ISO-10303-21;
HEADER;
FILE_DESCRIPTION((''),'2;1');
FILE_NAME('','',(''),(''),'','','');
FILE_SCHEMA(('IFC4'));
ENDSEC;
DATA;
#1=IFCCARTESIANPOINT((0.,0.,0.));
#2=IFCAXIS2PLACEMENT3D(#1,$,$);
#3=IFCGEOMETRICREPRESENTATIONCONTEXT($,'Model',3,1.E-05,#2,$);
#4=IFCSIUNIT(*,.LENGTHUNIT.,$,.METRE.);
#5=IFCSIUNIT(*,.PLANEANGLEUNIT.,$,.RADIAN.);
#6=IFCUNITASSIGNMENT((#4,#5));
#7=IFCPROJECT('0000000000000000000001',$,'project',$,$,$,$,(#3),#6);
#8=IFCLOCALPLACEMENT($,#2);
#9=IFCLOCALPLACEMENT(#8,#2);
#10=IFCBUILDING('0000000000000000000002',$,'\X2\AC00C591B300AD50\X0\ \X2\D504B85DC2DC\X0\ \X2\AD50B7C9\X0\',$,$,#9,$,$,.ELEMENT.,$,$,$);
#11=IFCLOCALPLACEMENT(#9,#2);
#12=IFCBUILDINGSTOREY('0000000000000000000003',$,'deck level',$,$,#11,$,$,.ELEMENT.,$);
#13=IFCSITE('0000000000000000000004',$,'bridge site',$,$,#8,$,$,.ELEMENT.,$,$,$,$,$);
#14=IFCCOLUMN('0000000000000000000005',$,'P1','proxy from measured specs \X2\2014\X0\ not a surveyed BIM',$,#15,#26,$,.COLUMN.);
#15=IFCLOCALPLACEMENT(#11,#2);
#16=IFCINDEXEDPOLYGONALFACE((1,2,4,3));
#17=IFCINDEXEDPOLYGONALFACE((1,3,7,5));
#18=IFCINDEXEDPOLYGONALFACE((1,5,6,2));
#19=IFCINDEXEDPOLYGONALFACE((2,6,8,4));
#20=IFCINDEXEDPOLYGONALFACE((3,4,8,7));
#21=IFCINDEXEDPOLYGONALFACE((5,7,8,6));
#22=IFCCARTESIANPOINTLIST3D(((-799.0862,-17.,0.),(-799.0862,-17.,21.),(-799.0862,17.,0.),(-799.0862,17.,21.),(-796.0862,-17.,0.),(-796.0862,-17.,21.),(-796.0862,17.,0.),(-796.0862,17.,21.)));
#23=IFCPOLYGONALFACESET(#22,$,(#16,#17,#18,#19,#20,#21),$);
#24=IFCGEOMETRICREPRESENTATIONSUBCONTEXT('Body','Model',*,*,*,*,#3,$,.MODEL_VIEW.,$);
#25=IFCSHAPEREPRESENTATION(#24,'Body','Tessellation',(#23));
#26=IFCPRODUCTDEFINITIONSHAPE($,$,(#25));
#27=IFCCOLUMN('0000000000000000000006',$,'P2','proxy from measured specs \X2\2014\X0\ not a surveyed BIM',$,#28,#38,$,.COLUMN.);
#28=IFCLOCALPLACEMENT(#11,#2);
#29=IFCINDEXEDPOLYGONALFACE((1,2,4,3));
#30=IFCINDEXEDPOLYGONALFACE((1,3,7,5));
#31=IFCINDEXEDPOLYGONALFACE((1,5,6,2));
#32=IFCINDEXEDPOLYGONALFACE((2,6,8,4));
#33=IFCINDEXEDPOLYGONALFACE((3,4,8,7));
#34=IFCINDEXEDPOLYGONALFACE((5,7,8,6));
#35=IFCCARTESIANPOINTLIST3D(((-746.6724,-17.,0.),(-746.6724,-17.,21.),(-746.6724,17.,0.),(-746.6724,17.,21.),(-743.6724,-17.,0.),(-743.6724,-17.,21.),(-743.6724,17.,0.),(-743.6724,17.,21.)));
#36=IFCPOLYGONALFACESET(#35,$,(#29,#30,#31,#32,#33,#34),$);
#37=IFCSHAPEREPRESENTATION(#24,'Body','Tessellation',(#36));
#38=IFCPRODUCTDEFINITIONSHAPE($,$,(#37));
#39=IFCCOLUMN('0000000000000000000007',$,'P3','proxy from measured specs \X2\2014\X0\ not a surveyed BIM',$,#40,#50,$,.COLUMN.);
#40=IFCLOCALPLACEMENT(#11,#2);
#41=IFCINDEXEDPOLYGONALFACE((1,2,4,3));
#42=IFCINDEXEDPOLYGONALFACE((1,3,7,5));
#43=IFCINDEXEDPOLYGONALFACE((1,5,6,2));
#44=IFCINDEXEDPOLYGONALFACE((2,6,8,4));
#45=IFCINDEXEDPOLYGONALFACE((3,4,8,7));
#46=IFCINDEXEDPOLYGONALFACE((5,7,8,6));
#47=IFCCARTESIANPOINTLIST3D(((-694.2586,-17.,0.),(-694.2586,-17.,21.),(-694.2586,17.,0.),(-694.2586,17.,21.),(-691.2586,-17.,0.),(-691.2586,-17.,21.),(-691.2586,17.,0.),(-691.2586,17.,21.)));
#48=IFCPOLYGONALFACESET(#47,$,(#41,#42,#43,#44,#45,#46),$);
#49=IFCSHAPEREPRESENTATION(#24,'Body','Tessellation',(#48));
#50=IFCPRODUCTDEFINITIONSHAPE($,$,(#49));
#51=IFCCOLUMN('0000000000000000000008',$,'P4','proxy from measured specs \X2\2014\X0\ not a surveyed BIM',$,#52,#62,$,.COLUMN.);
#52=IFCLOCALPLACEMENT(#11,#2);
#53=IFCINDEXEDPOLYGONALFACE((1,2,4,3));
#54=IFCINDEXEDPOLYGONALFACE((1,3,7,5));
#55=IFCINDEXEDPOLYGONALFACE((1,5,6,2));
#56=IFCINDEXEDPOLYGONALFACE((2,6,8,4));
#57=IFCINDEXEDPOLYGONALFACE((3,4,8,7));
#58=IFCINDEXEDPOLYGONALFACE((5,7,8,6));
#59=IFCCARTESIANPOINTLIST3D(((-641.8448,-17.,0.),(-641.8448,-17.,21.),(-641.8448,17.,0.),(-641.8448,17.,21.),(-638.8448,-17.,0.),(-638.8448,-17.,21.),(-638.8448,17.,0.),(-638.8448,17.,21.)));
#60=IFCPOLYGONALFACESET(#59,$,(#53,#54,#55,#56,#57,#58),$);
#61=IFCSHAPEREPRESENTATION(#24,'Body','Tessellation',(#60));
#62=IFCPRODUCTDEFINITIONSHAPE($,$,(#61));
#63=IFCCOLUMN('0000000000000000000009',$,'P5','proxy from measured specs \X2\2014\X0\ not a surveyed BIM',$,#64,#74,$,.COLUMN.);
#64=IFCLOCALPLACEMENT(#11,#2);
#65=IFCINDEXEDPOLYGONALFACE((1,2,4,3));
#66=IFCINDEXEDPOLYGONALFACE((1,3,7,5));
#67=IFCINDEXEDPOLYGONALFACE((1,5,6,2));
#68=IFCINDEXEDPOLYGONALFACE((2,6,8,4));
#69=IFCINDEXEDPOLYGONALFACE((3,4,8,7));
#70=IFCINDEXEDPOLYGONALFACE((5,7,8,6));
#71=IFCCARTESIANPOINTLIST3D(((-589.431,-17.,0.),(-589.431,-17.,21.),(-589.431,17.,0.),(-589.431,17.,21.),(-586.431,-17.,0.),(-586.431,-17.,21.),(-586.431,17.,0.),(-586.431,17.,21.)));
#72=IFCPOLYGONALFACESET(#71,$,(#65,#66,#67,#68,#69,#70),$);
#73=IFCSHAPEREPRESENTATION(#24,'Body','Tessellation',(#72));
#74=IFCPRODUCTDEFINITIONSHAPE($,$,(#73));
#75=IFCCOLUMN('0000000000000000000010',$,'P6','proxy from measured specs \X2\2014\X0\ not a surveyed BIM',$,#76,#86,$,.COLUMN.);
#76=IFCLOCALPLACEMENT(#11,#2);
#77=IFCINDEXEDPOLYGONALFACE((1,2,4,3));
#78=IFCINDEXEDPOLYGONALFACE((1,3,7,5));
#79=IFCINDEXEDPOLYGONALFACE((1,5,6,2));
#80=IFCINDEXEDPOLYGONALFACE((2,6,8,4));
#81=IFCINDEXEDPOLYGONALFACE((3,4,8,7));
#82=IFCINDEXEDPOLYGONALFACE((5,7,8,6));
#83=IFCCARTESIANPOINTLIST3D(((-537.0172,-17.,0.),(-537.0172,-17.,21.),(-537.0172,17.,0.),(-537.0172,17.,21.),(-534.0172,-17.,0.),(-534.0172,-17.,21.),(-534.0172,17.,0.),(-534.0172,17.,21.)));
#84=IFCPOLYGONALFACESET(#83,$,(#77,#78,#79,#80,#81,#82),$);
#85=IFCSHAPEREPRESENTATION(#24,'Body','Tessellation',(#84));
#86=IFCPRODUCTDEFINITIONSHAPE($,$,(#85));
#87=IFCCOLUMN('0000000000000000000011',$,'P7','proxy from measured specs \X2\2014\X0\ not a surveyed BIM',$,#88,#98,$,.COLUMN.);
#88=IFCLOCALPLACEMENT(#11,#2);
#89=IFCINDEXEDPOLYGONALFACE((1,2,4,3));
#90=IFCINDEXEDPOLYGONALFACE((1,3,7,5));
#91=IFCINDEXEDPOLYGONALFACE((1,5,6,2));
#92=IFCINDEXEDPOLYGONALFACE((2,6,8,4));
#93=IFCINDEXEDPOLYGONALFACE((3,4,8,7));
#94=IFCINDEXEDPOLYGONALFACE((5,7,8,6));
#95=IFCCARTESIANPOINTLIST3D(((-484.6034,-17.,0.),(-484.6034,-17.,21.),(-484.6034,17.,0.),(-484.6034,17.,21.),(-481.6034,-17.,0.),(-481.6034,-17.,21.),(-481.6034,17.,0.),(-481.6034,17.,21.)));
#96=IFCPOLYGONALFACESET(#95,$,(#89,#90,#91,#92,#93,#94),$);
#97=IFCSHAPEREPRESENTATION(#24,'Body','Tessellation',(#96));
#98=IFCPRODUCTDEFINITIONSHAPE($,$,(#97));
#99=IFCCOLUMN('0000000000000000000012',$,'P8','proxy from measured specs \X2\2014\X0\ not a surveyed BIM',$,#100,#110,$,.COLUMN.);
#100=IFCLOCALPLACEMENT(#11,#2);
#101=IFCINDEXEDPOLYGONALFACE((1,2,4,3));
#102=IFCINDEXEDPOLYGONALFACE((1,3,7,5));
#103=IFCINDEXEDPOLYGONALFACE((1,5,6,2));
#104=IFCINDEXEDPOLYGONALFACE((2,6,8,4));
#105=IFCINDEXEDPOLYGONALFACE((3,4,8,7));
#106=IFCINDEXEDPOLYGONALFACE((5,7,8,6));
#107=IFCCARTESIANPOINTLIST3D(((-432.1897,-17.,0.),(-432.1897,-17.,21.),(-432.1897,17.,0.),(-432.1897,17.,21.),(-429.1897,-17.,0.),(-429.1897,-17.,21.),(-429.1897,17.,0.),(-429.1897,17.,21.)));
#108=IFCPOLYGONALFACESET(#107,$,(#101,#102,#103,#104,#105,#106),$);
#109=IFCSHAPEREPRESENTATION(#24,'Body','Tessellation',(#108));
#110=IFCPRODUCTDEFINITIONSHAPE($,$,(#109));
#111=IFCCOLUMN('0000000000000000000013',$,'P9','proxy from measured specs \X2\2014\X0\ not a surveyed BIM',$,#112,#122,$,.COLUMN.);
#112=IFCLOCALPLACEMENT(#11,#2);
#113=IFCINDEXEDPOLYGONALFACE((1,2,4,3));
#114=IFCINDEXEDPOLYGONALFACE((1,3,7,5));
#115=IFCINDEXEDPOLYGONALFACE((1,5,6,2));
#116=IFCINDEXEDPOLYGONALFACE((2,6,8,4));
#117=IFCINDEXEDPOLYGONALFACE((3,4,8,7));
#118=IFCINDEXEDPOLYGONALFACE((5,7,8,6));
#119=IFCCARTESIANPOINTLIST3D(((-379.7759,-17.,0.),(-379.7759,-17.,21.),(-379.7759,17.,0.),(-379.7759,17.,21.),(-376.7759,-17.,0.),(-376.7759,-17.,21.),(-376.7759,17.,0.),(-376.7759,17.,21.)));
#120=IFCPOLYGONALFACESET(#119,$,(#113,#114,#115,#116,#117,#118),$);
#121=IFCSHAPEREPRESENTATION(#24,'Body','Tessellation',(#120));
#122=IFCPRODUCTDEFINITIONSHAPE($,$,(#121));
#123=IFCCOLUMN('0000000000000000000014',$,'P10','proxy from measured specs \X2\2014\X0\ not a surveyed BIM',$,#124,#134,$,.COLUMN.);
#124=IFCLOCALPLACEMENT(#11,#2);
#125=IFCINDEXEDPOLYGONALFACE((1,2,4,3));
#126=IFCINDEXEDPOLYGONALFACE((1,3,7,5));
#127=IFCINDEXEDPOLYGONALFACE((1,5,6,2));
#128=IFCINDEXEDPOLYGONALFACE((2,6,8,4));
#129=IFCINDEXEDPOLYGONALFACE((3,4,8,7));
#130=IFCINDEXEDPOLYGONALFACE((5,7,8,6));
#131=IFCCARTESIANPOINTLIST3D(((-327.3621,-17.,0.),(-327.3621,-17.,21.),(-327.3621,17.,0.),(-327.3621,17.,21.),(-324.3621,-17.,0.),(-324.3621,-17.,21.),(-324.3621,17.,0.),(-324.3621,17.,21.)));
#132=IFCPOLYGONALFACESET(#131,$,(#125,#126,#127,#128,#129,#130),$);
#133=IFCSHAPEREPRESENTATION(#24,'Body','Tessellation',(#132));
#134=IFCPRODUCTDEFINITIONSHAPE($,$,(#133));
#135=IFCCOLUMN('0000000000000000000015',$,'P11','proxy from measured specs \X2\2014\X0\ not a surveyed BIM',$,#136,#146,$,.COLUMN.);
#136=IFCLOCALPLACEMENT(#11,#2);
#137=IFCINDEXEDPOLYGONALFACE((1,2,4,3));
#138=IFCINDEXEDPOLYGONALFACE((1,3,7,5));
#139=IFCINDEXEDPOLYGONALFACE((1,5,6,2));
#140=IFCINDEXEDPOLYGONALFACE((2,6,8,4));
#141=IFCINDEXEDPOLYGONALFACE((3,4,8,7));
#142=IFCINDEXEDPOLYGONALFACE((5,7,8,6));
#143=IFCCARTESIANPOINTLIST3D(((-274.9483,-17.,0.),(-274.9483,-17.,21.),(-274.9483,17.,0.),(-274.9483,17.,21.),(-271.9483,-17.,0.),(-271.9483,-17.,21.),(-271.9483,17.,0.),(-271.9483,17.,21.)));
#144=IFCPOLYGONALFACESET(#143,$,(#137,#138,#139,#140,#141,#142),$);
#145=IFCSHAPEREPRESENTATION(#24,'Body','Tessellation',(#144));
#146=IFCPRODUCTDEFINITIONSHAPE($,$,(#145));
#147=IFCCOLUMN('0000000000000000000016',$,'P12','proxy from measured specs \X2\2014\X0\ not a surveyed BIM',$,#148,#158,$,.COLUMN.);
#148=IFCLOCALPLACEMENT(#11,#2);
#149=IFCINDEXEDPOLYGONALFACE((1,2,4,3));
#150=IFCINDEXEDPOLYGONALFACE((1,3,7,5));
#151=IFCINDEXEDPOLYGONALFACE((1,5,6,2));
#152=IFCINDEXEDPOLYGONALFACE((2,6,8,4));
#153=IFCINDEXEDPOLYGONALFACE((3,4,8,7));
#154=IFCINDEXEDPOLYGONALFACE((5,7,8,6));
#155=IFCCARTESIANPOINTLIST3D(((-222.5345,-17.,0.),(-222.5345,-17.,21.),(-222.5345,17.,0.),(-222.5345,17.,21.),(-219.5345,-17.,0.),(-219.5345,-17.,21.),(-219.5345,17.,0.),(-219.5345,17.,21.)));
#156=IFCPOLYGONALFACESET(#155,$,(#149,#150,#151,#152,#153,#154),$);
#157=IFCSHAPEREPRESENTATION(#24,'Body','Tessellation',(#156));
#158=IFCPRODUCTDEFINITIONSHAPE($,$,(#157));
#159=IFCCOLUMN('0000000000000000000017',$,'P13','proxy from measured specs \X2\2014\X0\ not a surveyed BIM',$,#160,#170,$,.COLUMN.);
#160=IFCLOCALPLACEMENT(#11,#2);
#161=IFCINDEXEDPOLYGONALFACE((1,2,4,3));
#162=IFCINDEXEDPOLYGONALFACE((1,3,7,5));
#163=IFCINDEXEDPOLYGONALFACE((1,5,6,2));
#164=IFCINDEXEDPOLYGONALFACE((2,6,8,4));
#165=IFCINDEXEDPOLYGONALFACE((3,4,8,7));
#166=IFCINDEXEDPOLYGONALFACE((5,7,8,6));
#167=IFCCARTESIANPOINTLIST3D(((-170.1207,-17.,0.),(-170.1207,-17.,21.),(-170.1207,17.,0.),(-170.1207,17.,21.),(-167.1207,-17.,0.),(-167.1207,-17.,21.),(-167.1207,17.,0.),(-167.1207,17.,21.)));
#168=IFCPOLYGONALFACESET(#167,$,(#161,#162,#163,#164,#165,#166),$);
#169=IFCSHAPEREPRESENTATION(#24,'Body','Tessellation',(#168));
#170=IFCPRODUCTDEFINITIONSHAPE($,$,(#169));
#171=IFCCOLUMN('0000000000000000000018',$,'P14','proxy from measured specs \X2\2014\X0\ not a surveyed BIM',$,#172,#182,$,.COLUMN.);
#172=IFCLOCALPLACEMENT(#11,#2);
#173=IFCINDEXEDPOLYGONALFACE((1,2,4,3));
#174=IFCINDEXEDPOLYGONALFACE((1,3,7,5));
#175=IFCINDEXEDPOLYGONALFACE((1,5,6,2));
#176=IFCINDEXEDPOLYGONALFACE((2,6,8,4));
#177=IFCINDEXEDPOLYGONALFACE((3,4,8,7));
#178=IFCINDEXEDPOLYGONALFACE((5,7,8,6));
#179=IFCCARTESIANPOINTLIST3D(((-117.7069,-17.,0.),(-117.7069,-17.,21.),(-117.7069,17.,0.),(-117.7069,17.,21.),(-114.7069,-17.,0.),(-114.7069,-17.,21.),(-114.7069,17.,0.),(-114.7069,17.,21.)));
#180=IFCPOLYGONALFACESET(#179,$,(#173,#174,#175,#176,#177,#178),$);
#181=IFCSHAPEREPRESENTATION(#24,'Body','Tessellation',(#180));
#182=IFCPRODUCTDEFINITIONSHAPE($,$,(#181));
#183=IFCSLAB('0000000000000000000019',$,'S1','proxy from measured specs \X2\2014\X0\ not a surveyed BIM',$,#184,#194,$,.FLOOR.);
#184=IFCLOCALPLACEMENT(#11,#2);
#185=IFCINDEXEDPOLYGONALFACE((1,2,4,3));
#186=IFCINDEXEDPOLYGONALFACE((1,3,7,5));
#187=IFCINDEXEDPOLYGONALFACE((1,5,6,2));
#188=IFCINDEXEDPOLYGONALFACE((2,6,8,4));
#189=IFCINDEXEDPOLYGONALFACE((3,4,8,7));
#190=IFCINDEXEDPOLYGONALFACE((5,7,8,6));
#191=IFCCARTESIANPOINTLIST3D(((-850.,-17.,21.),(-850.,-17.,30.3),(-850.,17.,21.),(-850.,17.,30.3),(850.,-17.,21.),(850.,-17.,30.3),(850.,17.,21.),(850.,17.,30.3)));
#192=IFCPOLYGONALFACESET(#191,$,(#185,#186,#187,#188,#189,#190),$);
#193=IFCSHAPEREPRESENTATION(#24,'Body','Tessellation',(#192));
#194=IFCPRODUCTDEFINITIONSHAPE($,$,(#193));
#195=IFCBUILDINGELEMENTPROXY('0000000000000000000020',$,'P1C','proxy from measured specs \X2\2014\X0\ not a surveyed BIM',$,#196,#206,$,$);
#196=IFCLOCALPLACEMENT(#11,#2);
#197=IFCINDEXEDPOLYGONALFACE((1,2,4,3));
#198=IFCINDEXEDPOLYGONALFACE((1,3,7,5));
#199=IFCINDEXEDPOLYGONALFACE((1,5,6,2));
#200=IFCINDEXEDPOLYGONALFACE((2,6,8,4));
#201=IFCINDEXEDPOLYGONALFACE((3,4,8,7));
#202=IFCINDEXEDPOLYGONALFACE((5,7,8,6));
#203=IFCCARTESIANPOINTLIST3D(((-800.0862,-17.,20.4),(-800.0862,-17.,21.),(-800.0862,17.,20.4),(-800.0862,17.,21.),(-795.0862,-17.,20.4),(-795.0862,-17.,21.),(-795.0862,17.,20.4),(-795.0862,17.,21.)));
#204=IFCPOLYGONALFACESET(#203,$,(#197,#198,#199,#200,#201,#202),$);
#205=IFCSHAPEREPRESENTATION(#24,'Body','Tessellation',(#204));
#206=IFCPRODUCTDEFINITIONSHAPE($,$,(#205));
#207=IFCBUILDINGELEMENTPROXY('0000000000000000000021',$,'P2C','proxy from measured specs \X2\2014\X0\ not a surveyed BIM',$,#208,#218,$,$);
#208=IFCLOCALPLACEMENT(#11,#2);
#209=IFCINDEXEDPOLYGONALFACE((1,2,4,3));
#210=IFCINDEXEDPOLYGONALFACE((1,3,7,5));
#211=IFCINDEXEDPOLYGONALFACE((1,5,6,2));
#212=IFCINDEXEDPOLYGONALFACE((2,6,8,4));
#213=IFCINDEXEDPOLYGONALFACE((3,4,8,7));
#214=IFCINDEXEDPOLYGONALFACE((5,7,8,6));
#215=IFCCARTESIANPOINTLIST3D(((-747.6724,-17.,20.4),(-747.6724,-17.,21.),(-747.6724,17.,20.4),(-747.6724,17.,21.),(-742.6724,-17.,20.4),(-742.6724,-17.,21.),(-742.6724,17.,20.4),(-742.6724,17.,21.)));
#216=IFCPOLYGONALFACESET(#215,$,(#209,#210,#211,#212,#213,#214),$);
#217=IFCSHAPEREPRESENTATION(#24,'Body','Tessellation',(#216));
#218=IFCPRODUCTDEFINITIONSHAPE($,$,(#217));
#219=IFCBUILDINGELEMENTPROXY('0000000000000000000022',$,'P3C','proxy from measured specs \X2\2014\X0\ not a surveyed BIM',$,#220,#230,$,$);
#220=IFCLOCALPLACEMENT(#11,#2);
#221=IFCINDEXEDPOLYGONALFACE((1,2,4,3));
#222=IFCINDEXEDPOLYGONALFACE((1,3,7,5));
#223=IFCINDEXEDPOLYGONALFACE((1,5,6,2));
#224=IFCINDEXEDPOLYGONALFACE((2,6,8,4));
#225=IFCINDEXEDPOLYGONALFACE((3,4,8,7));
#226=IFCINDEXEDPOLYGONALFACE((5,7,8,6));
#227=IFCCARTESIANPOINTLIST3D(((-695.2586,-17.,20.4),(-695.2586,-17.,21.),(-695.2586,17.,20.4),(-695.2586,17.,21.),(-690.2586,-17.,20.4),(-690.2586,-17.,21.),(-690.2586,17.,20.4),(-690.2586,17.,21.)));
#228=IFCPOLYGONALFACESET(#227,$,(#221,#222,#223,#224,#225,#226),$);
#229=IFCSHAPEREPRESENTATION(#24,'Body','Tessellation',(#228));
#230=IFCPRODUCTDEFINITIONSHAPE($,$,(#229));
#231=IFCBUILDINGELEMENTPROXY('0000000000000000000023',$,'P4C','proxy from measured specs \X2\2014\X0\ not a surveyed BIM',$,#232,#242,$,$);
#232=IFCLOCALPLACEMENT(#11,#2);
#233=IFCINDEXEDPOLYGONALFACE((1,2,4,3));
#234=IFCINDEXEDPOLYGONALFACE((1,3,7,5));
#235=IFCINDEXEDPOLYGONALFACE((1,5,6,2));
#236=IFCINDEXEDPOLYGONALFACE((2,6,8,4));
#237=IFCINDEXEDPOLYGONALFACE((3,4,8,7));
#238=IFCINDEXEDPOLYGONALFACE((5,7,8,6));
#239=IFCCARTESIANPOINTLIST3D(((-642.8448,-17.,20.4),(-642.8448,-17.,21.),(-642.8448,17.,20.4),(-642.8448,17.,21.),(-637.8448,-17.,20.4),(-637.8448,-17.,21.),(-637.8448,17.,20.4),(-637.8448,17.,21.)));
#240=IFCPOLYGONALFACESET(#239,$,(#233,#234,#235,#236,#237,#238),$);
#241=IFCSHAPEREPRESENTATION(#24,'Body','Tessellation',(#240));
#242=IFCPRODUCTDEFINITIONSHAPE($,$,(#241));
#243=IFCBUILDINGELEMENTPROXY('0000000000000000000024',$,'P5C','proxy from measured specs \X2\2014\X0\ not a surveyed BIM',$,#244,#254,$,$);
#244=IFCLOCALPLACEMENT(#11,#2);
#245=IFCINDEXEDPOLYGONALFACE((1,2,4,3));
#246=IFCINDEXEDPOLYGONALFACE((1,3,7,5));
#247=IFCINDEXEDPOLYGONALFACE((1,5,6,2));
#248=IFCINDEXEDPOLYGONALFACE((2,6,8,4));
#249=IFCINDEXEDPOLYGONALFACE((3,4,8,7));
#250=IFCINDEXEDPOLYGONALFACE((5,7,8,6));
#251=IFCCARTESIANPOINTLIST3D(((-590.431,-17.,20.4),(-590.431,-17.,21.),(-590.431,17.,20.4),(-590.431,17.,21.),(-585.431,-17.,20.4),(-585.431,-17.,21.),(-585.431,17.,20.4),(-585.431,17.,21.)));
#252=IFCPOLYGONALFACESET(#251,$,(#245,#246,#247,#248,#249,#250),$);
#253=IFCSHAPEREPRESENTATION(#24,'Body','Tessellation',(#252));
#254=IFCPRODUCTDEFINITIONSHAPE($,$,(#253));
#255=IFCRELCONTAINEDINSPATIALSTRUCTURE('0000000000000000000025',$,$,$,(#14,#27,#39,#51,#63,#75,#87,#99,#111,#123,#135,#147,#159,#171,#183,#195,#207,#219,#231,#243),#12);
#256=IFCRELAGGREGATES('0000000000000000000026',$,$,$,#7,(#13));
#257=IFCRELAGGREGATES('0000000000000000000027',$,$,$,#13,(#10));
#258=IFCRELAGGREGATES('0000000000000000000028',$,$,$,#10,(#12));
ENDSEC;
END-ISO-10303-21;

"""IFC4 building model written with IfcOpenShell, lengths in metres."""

from ifc_helpers import new_model, si_unit, frame, origin, origin_2d, place, context, subcontext, project, spatial, rectangle, extrude, element, save


model = new_model("IFC4")

# Units and contexts
model_context = context("Model", 3, precision=1e-05, world=origin())
body_context = subcontext(model_context, "Body", "Model", "MODEL_VIEW")
ifc_project = project(units=[si_unit("LENGTHUNIT", "METRE"), si_unit("PLANEANGLEUNIT", "RADIAN")], contexts=[model_context])

# Site, building, storey
site_placement = place(None, origin())
site = spatial("IfcSite", under=ifc_project, at=site_placement, Name="bridge site", CompositionType="ELEMENT")
building_placement = place(site_placement, origin())
building = spatial("IfcBuilding", under=site, at=building_placement, Name="가양대교 프록시 교량", CompositionType="ELEMENT")
storey_placement = place(building_placement, origin())
storey = spatial("IfcBuildingStorey", under=building, at=storey_placement, Name="deck level", CompositionType="ELEMENT")

# Columns
for number, where, name in (
    (1, (-797.5862, 0.0, 0.0), "P1"),
    (2, (-745.1724, 0.0, 0.0), "P2"),
    (3, (-692.7586, 0.0, 0.0), "P3"),
    (4, (-640.3448, 0.0, 0.0), "P4"),
    (5, (-587.931, 0.0, 0.0), "P5"),
    (6, (-535.5172, 0.0, 0.0), "P6"),
    (7, (-483.1034, 0.0, 0.0), "P7"),
    (8, (-430.6897, 0.0, 0.0), "P8"),
    (9, (-378.2759, 0.0, 0.0), "P9"),
    (10, (-325.8621, 0.0, 0.0), "P10"),
    (11, (-273.4483, 0.0, 0.0), "P11"),
    (12, (-221.0345, 0.0, 0.0), "P12"),
    (13, (-168.6207, 0.0, 0.0), "P13"),
    (14, (-116.2069, 0.0, 0.0), "P14"),
):
    element("IfcColumn", number, at=place(storey_placement, frame(where)), inside=storey, Name=name, Description="proxy from measured specs — not a surveyed BIM", PredefinedType="COLUMN", context=body_context, shape_type="SweptSolid", body=[
        extrude(rectangle(XDim=3.0, YDim=34.0, at=origin_2d()), origin(), (0.0, 0.0, 1.0), 21.0),
    ])

# Slab
slab_placement = place(storey_placement, frame((0.0, 0.0, 21.0)))
element("IfcSlab", 15, at=slab_placement, inside=storey, Name="S1", Description="proxy from measured specs — not a surveyed BIM", PredefinedType="FLOOR", context=body_context, shape_type="SweptSolid", body=[
    extrude(rectangle(XDim=1700.0, YDim=34.0, at=origin_2d()), origin(), (0.0, 0.0, 1.0), 9.3),
])

# Building element proxies
for number, where, name in (
    (16, (-797.5862, 0.0, 20.4), "P1C"),
    (17, (-745.1724, 0.0, 20.4), "P2C"),
    (18, (-692.7586, 0.0, 20.4), "P3C"),
    (19, (-640.3448, 0.0, 20.4), "P4C"),
    (20, (-587.931, 0.0, 20.4), "P5C"),
):
    element("IfcBuildingElementProxy", number, at=place(storey_placement, frame(where)), inside=storey, Name=name, Description="proxy from measured specs — not a surveyed BIM", context=body_context, shape_type="SweptSolid", body=[
        extrude(rectangle(XDim=5.0, YDim=34.0, at=origin_2d()), origin(), (0.0, 0.0, 1.0), 0.6),
    ])

save(model, "model.ifc")
